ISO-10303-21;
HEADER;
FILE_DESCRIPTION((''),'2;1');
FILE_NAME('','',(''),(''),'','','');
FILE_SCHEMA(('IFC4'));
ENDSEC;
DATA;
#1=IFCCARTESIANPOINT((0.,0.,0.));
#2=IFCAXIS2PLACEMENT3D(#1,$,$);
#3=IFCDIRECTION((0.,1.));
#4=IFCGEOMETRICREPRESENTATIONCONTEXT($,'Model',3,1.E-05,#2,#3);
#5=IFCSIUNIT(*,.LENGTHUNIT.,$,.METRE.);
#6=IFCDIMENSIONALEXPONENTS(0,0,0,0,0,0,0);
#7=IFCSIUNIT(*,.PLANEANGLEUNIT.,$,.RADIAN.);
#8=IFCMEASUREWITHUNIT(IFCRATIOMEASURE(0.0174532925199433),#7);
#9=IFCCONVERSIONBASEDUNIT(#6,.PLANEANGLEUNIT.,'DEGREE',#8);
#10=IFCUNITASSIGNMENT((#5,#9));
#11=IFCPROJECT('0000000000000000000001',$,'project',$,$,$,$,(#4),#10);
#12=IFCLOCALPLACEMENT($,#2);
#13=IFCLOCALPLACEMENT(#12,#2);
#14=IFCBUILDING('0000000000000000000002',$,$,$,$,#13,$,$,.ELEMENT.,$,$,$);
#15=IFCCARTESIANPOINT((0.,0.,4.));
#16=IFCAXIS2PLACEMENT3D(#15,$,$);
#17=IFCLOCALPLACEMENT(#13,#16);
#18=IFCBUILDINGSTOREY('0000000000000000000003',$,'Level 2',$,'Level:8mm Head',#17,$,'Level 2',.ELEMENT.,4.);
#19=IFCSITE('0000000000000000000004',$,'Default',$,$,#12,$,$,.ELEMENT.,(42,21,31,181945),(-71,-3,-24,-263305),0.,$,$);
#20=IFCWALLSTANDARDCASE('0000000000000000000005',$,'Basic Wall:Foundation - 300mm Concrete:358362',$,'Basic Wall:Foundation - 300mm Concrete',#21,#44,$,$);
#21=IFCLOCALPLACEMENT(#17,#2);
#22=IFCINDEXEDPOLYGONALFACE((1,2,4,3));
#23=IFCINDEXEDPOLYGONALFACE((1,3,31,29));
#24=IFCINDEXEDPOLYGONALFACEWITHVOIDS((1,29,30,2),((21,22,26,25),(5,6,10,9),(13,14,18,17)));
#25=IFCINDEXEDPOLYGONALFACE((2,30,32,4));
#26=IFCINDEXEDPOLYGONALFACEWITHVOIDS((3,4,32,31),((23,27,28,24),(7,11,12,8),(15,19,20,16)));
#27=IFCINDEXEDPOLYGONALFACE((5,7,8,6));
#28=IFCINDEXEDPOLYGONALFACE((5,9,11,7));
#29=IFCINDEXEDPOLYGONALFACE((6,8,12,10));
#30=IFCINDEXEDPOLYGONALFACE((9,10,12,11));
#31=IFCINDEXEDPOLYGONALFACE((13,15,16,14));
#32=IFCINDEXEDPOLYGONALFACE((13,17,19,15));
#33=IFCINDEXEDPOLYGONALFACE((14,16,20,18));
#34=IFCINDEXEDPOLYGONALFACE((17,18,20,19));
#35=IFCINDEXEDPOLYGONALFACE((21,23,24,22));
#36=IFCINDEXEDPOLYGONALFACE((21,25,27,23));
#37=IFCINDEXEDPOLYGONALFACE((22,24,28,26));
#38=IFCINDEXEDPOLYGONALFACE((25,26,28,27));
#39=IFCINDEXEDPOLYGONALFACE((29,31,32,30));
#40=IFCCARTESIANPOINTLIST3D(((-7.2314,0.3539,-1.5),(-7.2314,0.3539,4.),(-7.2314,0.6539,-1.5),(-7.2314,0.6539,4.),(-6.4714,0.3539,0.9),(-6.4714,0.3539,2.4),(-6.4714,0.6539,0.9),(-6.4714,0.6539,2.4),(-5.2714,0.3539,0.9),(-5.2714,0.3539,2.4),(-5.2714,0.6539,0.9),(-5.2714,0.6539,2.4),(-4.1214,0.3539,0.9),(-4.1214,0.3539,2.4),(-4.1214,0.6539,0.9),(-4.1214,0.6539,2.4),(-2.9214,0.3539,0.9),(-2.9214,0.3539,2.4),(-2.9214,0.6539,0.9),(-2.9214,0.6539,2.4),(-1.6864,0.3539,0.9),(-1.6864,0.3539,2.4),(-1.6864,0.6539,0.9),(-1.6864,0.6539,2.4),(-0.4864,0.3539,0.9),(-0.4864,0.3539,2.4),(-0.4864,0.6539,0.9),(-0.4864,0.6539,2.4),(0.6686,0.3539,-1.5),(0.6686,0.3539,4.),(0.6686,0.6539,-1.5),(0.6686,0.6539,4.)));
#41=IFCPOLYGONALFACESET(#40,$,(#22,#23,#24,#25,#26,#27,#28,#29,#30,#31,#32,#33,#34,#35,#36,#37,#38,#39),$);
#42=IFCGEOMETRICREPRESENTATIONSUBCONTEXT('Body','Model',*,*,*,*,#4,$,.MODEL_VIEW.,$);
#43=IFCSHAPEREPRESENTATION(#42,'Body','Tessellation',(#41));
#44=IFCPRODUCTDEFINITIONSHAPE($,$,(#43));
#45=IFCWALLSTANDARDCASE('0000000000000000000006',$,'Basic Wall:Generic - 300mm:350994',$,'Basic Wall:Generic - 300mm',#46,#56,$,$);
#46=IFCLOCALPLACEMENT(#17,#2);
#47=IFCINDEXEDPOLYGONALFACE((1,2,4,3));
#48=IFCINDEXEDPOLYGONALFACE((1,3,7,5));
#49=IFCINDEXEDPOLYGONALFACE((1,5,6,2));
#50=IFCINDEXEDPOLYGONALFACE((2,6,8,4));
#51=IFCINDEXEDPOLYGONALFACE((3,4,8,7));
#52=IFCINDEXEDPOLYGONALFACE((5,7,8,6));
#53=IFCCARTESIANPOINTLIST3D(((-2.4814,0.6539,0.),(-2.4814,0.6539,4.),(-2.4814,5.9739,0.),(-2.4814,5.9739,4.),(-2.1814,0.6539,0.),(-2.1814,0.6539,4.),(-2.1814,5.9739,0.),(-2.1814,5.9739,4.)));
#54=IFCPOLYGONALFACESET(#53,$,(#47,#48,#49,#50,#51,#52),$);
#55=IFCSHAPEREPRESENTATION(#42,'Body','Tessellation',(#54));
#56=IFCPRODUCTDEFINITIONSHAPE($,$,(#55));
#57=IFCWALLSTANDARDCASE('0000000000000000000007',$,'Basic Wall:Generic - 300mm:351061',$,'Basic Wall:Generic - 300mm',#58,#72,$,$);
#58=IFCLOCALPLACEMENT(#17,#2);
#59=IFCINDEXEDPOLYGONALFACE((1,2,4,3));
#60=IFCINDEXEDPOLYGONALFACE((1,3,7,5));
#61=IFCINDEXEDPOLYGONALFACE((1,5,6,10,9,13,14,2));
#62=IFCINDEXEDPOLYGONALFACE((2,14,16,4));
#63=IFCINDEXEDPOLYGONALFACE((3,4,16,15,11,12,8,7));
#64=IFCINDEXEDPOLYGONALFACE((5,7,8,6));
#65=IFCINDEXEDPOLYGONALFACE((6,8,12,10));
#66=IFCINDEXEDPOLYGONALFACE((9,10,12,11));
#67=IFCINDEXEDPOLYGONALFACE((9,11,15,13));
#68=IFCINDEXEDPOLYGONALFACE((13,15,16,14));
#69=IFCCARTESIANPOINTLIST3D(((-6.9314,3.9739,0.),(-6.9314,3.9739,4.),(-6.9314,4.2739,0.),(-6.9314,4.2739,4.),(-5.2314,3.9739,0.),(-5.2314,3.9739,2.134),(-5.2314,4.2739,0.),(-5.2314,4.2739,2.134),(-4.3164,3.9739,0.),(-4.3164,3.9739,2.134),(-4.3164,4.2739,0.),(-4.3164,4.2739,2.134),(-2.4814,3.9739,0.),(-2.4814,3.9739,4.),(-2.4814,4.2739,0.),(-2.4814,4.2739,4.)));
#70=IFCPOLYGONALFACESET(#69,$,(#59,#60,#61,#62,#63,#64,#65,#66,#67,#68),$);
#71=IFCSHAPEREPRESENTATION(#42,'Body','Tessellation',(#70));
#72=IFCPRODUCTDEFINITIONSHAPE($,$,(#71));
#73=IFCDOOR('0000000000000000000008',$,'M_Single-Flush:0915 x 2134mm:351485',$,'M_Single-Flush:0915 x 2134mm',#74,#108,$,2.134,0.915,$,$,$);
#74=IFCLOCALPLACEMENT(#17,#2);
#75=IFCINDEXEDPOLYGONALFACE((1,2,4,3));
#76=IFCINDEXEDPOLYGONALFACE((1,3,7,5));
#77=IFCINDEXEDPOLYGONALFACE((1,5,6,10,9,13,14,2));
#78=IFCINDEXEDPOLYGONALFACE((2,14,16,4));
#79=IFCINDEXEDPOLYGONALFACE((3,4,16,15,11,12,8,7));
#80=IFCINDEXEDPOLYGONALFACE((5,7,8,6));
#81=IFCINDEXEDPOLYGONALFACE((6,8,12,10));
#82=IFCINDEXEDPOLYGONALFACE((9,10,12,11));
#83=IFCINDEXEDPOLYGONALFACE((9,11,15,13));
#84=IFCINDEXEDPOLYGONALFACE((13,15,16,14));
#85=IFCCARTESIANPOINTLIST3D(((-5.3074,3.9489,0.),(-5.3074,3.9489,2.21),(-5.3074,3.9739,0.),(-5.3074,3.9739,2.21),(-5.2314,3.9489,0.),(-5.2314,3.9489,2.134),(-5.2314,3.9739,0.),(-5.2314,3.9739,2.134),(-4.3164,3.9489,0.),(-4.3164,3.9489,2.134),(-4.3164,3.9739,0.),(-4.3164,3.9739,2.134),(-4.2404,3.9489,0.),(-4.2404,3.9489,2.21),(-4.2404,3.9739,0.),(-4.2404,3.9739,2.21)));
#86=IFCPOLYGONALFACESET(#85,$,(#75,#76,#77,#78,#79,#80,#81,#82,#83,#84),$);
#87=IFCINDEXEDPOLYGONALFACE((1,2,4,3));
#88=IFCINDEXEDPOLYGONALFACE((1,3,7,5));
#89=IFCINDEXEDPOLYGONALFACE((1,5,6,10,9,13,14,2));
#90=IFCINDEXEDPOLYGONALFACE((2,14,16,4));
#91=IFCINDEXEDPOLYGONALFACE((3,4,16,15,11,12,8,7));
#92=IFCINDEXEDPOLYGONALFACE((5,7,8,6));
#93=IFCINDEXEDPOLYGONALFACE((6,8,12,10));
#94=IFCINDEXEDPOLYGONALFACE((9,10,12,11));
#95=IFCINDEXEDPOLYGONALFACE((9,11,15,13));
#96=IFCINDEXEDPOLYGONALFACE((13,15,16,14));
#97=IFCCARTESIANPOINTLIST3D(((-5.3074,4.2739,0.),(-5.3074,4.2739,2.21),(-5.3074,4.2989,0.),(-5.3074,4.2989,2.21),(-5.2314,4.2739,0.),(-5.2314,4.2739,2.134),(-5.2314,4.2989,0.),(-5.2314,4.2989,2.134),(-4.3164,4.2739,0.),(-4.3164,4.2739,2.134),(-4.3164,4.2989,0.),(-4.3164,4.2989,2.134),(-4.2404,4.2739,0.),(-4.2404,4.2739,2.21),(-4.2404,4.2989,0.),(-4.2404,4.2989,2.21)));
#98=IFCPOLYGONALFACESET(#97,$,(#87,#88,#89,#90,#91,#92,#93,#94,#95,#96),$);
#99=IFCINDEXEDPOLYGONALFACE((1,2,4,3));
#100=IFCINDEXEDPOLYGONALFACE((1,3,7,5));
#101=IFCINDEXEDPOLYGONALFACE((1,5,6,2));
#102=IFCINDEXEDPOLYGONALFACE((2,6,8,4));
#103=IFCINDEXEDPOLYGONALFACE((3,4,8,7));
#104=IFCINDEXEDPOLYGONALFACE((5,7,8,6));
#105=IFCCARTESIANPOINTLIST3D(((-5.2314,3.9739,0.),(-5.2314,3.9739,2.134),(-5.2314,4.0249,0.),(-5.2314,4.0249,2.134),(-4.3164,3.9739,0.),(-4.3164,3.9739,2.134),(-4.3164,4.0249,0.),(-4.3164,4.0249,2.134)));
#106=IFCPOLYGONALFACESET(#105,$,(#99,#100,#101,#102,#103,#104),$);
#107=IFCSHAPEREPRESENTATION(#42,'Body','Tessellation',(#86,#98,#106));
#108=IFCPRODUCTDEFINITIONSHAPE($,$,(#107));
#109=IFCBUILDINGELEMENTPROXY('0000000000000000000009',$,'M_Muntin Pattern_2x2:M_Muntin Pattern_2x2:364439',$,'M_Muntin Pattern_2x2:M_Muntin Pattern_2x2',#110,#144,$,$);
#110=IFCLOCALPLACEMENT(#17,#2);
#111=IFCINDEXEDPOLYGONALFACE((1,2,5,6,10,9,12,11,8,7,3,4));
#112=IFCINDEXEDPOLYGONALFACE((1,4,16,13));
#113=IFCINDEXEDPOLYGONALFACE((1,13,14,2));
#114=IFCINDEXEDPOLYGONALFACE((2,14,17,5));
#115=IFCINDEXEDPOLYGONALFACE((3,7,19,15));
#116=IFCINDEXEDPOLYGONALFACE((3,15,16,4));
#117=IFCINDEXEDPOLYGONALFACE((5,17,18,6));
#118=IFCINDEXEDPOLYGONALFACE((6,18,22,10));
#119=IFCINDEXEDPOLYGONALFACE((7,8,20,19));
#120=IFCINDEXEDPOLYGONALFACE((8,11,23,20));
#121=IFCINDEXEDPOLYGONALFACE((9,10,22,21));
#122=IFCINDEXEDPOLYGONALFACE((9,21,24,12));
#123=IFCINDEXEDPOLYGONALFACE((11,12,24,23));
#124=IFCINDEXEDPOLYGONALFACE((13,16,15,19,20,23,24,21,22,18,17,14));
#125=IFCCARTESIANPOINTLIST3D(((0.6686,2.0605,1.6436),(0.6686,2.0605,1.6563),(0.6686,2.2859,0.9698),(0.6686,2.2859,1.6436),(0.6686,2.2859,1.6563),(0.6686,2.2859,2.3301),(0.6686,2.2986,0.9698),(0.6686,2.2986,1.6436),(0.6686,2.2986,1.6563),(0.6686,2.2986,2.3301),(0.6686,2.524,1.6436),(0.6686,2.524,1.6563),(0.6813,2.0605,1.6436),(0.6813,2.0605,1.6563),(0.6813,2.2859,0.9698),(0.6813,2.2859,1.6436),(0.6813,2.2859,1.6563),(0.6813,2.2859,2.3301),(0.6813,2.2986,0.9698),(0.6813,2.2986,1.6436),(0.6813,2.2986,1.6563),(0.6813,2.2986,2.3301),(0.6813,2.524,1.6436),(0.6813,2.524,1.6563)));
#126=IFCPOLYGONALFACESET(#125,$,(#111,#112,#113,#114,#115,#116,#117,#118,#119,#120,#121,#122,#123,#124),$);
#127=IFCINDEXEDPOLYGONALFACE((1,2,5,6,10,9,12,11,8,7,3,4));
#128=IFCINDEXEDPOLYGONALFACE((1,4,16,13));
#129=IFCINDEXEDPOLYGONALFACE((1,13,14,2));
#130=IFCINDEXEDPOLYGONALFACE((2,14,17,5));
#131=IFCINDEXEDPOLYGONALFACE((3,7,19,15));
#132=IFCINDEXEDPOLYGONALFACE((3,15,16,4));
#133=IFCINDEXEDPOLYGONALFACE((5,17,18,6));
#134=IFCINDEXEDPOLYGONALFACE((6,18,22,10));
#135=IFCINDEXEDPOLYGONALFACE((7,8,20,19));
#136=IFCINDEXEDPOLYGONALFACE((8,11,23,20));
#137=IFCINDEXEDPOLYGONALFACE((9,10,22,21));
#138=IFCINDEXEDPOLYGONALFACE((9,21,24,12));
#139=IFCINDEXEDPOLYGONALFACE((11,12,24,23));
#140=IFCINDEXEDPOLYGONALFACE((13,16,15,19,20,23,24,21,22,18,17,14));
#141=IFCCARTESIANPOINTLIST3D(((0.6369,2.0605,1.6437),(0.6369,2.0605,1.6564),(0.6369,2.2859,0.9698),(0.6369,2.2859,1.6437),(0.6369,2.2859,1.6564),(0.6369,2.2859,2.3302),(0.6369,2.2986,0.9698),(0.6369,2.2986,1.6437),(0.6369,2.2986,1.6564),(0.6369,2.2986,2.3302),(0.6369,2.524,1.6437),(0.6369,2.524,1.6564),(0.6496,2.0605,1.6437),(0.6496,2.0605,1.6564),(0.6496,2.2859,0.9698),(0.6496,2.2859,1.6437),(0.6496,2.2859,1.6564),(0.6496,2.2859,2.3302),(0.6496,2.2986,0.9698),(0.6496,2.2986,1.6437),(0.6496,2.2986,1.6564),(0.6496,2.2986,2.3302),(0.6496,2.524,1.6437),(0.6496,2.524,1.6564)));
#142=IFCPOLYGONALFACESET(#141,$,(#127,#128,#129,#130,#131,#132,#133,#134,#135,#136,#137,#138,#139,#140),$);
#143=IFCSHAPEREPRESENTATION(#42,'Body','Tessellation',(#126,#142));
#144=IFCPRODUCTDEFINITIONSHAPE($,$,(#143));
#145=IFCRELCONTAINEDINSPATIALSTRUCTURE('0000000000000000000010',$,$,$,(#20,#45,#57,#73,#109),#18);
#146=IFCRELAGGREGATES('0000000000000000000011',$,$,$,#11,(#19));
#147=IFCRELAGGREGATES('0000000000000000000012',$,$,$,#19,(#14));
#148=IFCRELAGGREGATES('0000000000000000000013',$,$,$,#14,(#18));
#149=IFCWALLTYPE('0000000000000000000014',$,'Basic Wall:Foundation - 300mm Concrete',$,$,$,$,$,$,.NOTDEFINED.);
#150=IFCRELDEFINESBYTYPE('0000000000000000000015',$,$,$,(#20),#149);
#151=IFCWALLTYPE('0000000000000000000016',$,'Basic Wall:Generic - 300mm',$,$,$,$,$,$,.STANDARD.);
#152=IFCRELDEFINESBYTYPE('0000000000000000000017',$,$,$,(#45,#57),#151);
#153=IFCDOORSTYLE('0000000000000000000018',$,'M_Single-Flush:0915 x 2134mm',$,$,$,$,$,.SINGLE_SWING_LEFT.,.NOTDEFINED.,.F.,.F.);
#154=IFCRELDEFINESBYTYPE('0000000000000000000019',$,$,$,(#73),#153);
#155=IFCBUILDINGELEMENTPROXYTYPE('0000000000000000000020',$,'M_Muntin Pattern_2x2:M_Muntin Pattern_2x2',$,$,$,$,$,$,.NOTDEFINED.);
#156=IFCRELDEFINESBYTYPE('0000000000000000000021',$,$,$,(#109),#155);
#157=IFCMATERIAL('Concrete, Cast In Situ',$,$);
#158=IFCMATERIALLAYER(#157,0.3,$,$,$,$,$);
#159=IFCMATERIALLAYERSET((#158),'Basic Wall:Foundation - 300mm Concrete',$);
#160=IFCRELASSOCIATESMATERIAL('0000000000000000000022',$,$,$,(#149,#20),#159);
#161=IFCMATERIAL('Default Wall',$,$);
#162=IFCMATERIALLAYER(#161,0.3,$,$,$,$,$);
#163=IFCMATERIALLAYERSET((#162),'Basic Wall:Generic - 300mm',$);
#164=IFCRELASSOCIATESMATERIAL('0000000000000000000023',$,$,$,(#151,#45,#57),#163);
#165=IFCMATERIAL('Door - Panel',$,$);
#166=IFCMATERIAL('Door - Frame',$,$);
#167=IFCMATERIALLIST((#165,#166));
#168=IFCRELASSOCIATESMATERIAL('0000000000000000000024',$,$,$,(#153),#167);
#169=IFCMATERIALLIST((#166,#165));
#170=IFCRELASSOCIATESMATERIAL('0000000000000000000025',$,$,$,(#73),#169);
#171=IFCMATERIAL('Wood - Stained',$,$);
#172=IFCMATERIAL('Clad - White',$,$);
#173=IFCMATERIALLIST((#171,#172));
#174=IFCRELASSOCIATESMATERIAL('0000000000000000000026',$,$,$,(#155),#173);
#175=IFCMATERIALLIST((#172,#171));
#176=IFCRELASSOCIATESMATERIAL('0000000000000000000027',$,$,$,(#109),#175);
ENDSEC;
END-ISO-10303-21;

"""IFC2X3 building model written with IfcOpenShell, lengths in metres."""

from ifc_helpers import new_model, entity, si_unit, converted_unit, direction, frame, frame_2d, origin, place, context, subcontext, project, spatial, polyline, rectangle, outline, extrude, source, transform, mapped, material, material_list, layer, layer_set, layer_usage, type_object, type_shapes, element, fill, save


model = new_model("IFC2X3")

# Units and contexts
model_context = context("Model", 3, precision=1e-05, world=origin(), true_north=direction((0.0, 1.0)))
body_context = subcontext(model_context, "Body", "Model", "MODEL_VIEW")
ifc_project = project(units=[si_unit("LENGTHUNIT", "METRE"), converted_unit("PLANEANGLEUNIT", "DEGREE", entity("IfcRatioMeasure", 0.0174532925199433), si_unit("PLANEANGLEUNIT", "RADIAN"), dimensions=[0, 0, 0, 0, 0, 0, 0])], contexts=[model_context])

# Site, building, storey
site_placement = place(None, origin())
site = spatial("IfcSite", under=ifc_project, at=site_placement, Name="Default", CompositionType="ELEMENT", RefLatitude=(42, 21, 31, 181945), RefLongitude=(-71, -3, -24, -263305), RefElevation=0.0)
building_placement = place(site_placement, origin())
building = spatial("IfcBuilding", under=site, at=building_placement, CompositionType="ELEMENT")
storey_placement = place(building_placement, frame((0.0, 0.0, 4.0)))
storey = spatial("IfcBuildingStorey", under=building, at=storey_placement, Name="Level 2", ObjectType="Level:8mm Head", LongName="Level 2", CompositionType="ELEMENT", Elevation=4.0)

# Wall, openings
ifc_material_1 = material(Name="Concrete, Cast In Situ")
ifc_layer_1 = layer(ifc_material_1, 0.3)
ifc_layer_set_1 = layer_set([ifc_layer_1], Name="Basic Wall:Foundation - 300mm Concrete")
ifc_layer_usage_1 = layer_usage(ifc_layer_set_1, "AXIS2", "NEGATIVE", 0.15)
wall_type_1 = type_object("IfcWallType", Name="Basic Wall:Foundation - 300mm Concrete", PredefinedType="NOTDEFINED", material=ifc_layer_set_1)
wall_1_placement = place(storey_placement, frame((0.6686, 0.5039, -1.5), z_axis=(0.0, 0.0, 1.0), x_axis=(-1.0, 0.0, 0.0)))
wall_1 = element("IfcWallStandardCase", 1, at=wall_1_placement, inside=storey, type_object=wall_type_1, material=ifc_layer_usage_1, Name="Basic Wall:Foundation - 300mm Concrete:358362", ObjectType="Basic Wall:Foundation - 300mm Concrete", context=body_context, shape_type="SweptSolid", body=[
    extrude(rectangle(XDim=7.9, YDim=0.3, at=frame_2d((3.95, 0.0), x_axis=(-1.0, 0.0))), origin(), (0.0, 0.0, 1.0), 5.5),
])
opening_1_placement = place(wall_1_placement, frame((1.155, -0.15, 2.4)))
element("IfcOpeningElement", 2, at=opening_1_placement, cuts=wall_1, ObjectType="Opening", context=body_context, shape_type="SweptSolid", body=[
    extrude(rectangle(XDim=1.5, YDim=1.2, at=frame_2d((0.75, 0.6), x_axis=(-1.0, 0.0))), frame((0.0, 0.0, 0.0), z_axis=(0.0, 1.0, 0.0), x_axis=(0.0, 0.0, 1.0)), (0.0, 0.0, 1.0), 0.3),
])
opening_2_placement = place(wall_1_placement, frame((3.59, -0.15, 2.4)))
element("IfcOpeningElement", 3, at=opening_2_placement, cuts=wall_1, ObjectType="Opening", context=body_context, shape_type="SweptSolid", body=[
    extrude(rectangle(XDim=1.5, YDim=1.2, at=frame_2d((0.75, 0.6), x_axis=(-1.0, 0.0))), frame((0.0, 0.0, 0.0), z_axis=(0.0, 1.0, 0.0), x_axis=(0.0, 0.0, 1.0)), (0.0, 0.0, 1.0), 0.3),
])
opening_3_placement = place(wall_1_placement, frame((5.94, -0.15, 2.4)))
element("IfcOpeningElement", 4, at=opening_3_placement, cuts=wall_1, ObjectType="Opening", context=body_context, shape_type="SweptSolid", body=[
    extrude(rectangle(XDim=1.5, YDim=1.2, at=frame_2d((0.75, 0.6), x_axis=(-1.0, 0.0))), frame((0.0, 0.0, 0.0), z_axis=(0.0, 1.0, 0.0), x_axis=(0.0, 0.0, 1.0)), (0.0, 0.0, 1.0), 0.3),
])

# Wall
ifc_material_2 = material(Name="Default Wall")
ifc_layer_2 = layer(ifc_material_2, 0.3)
ifc_layer_set_2 = layer_set([ifc_layer_2], Name="Basic Wall:Generic - 300mm")
ifc_layer_usage_2 = layer_usage(ifc_layer_set_2, "AXIS2", "NEGATIVE", 0.15)
wall_type_2 = type_object("IfcWallType", Name="Basic Wall:Generic - 300mm", PredefinedType="STANDARD", material=ifc_layer_set_2)
wall_2_placement = place(storey_placement, frame((-2.3314, 0.6539, 0.0), z_axis=(0.0, 0.0, 1.0), x_axis=(0.0, 1.0, 0.0)))
element("IfcWallStandardCase", 5, at=wall_2_placement, inside=storey, type_object=wall_type_2, material=ifc_layer_usage_2, Name="Basic Wall:Generic - 300mm:350994", ObjectType="Basic Wall:Generic - 300mm", context=body_context, shape_type="SweptSolid", body=[
    extrude(rectangle(XDim=5.32, YDim=0.3, at=frame_2d((2.66, 0.0), x_axis=(-1.0, 0.0))), origin(), (0.0, 0.0, 1.0), 4.0),
])

# Wall, opening, door
ifc_layer_usage_3 = layer_usage(ifc_layer_set_2, "AXIS2", "NEGATIVE", 0.15)
wall_3_placement = place(storey_placement, frame((-2.4814, 4.1239, 0.0), z_axis=(0.0, 0.0, 1.0), x_axis=(-1.0, 0.0, 0.0)))
wall_3 = element("IfcWallStandardCase", 6, at=wall_3_placement, inside=storey, type_object=wall_type_2, material=ifc_layer_usage_3, Name="Basic Wall:Generic - 300mm:351061", ObjectType="Basic Wall:Generic - 300mm", context=body_context, shape_type="SweptSolid", body=[
    extrude(rectangle(XDim=4.45, YDim=0.3, at=frame_2d((2.225, 0.0), x_axis=(-1.0, 0.0))), origin(), (0.0, 0.0, 1.0), 4.0),
])
opening_4_placement = place(wall_3_placement, frame((1.835, -0.15, 0.0)))
opening_4 = element("IfcOpeningElement", 7, at=opening_4_placement, cuts=wall_3, ObjectType="Opening", context=body_context, shape_type="SweptSolid", body=[
    extrude(rectangle(XDim=0.915, YDim=2.134, at=frame_2d((1.067, 0.4575), x_axis=(0.0, -1.0))), frame((0.0, 0.0, 0.0), z_axis=(0.0, 1.0, 0.0), x_axis=(0.0, 0.0, 1.0)), (0.0, 0.0, 1.0), 0.3),
])
ifc_material_3 = material(Name="Door - Frame")
ifc_material_4 = material(Name="Door - Panel")
ifc_material_list_1 = material_list([ifc_material_3, ifc_material_4])
ifc_material_list_2 = material_list([ifc_material_4, ifc_material_3])
door_style = type_object("IfcDoorStyle", Name="M_Single-Flush:0915 x 2134mm", ConstructionType="NOTDEFINED", OperationType="SINGLE_SWING_LEFT", ParameterTakesPrecedence=False, Sizeable=False, material=ifc_material_list_2)
shared_shape_1 = source(origin(), body_context, "Body", "SweptSolid", [
    extrude(outline(polyline([(-0.5335, -1.124), (0.5335, -1.124), (0.5335, 1.086), (0.4575, 1.086), (0.4575, -1.048), (-0.4575, -1.048), (-0.4575, 1.086), (-0.5335, 1.086), (-0.5335, -1.124)])), frame((0.4575, 0.325, 1.086), z_axis=(0.0, -1.0, 0.0), x_axis=(-1.0, 0.0, 0.0)), (0.0, 0.0, 1.0), 0.025),
    extrude(outline(polyline([(-1.124, -0.5335), (1.086, -0.5335), (1.086, -0.4575), (-1.048, -0.4575), (-1.048, 0.4575), (1.086, 0.4575), (1.086, 0.5335), (-1.124, 0.5335), (-1.124, -0.5335)])), frame((0.4575, 0.0, 1.086), z_axis=(0.0, -1.0, 0.0), x_axis=(0.0, 0.0, -1.0)), (0.0, 0.0, 1.0), 0.025),
    extrude(rectangle(XDim=0.915, YDim=0.051, at=frame_2d((0.0, 0.0), x_axis=(1.0, 0.0))), frame((0.4575, 0.2745, 0.0)), (0.0, 0.0, 1.0), 2.134),
])
type_shapes(door_style, [shared_shape_1])
door_placement = place(opening_4_placement, origin())
door = element("IfcDoor", 8, at=door_placement, inside=storey, type_object=door_style, material=ifc_material_list_1, Name="M_Single-Flush:0915 x 2134mm:351485", ObjectType="M_Single-Flush:0915 x 2134mm", OverallHeight=2.134, OverallWidth=0.915, context=body_context, shape_type="MappedRepresentation", body=[
    mapped(shared_shape_1, transform((0.0, 0.0, 0.0), scale=1.0)),
])
fill(opening_4, door)

# Building element proxy
ifc_material_5 = material(Name="Clad - White")
ifc_material_6 = material(Name="Wood - Stained")
ifc_material_list_3 = material_list([ifc_material_5, ifc_material_6])
ifc_material_list_4 = material_list([ifc_material_6, ifc_material_5])
building_element_proxy_type_1 = type_object("IfcBuildingElementProxyType", Name="M_Muntin Pattern_2x2:M_Muntin Pattern_2x2", PredefinedType="NOTDEFINED", material=ifc_material_list_4)
shared_shape_2 = source(origin(), body_context, "Body", "SweptSolid", [
    extrude(outline(polyline([(0.0064, -0.0064), (0.6801, -0.0064), (0.6801, 0.0063), (0.0064, 0.0063), (0.0064, 0.2317), (-0.0063, 0.2317), (-0.0063, 0.0063), (-0.6802, 0.0063), (-0.6802, -0.0064), (-0.0063, -0.0064), (-0.0063, -0.2317), (0.0064, -0.2317), (0.0064, -0.0064)])), frame((0.0, 0.0095, 0.6801), z_axis=(0.0, 1.0, 0.0), x_axis=(0.0, 0.0, 1.0)), (0.0, 0.0, 1.0), 0.0127),
    extrude(outline(polyline([(0.0064, -0.0064), (0.6802, -0.0064), (0.6802, 0.0063), (0.0064, 0.0063), (0.0064, 0.2317), (-0.0063, 0.2317), (-0.0063, 0.0063), (-0.6802, 0.0063), (-0.6802, -0.0064), (-0.0063, -0.0064), (-0.0063, -0.2317), (0.0064, -0.2317), (0.0064, -0.0064)])), frame((0.0, -0.0222, 0.6802), z_axis=(0.0, 1.0, 0.0), x_axis=(0.0, 0.0, 1.0)), (0.0, 0.0, 1.0), 0.0127),
])
type_shapes(building_element_proxy_type_1, [shared_shape_2])
proxy_1_placement = place(storey_placement, frame((0.6591, 2.2923, 0.9698), z_axis=(0.0, 0.0, 1.0), x_axis=(0.0, -1.0, 0.0)))
element("IfcBuildingElementProxy", 9, at=proxy_1_placement, inside=storey, type_object=building_element_proxy_type_1, material=ifc_material_list_3, Name="M_Muntin Pattern_2x2:M_Muntin Pattern_2x2:364439", ObjectType="M_Muntin Pattern_2x2:M_Muntin Pattern_2x2", context=body_context, shape_type="MappedRepresentation", body=[
    mapped(shared_shape_2, transform((0.0, 0.0, 0.0), scale=1.0)),
])

save(model, "model.ifc")
